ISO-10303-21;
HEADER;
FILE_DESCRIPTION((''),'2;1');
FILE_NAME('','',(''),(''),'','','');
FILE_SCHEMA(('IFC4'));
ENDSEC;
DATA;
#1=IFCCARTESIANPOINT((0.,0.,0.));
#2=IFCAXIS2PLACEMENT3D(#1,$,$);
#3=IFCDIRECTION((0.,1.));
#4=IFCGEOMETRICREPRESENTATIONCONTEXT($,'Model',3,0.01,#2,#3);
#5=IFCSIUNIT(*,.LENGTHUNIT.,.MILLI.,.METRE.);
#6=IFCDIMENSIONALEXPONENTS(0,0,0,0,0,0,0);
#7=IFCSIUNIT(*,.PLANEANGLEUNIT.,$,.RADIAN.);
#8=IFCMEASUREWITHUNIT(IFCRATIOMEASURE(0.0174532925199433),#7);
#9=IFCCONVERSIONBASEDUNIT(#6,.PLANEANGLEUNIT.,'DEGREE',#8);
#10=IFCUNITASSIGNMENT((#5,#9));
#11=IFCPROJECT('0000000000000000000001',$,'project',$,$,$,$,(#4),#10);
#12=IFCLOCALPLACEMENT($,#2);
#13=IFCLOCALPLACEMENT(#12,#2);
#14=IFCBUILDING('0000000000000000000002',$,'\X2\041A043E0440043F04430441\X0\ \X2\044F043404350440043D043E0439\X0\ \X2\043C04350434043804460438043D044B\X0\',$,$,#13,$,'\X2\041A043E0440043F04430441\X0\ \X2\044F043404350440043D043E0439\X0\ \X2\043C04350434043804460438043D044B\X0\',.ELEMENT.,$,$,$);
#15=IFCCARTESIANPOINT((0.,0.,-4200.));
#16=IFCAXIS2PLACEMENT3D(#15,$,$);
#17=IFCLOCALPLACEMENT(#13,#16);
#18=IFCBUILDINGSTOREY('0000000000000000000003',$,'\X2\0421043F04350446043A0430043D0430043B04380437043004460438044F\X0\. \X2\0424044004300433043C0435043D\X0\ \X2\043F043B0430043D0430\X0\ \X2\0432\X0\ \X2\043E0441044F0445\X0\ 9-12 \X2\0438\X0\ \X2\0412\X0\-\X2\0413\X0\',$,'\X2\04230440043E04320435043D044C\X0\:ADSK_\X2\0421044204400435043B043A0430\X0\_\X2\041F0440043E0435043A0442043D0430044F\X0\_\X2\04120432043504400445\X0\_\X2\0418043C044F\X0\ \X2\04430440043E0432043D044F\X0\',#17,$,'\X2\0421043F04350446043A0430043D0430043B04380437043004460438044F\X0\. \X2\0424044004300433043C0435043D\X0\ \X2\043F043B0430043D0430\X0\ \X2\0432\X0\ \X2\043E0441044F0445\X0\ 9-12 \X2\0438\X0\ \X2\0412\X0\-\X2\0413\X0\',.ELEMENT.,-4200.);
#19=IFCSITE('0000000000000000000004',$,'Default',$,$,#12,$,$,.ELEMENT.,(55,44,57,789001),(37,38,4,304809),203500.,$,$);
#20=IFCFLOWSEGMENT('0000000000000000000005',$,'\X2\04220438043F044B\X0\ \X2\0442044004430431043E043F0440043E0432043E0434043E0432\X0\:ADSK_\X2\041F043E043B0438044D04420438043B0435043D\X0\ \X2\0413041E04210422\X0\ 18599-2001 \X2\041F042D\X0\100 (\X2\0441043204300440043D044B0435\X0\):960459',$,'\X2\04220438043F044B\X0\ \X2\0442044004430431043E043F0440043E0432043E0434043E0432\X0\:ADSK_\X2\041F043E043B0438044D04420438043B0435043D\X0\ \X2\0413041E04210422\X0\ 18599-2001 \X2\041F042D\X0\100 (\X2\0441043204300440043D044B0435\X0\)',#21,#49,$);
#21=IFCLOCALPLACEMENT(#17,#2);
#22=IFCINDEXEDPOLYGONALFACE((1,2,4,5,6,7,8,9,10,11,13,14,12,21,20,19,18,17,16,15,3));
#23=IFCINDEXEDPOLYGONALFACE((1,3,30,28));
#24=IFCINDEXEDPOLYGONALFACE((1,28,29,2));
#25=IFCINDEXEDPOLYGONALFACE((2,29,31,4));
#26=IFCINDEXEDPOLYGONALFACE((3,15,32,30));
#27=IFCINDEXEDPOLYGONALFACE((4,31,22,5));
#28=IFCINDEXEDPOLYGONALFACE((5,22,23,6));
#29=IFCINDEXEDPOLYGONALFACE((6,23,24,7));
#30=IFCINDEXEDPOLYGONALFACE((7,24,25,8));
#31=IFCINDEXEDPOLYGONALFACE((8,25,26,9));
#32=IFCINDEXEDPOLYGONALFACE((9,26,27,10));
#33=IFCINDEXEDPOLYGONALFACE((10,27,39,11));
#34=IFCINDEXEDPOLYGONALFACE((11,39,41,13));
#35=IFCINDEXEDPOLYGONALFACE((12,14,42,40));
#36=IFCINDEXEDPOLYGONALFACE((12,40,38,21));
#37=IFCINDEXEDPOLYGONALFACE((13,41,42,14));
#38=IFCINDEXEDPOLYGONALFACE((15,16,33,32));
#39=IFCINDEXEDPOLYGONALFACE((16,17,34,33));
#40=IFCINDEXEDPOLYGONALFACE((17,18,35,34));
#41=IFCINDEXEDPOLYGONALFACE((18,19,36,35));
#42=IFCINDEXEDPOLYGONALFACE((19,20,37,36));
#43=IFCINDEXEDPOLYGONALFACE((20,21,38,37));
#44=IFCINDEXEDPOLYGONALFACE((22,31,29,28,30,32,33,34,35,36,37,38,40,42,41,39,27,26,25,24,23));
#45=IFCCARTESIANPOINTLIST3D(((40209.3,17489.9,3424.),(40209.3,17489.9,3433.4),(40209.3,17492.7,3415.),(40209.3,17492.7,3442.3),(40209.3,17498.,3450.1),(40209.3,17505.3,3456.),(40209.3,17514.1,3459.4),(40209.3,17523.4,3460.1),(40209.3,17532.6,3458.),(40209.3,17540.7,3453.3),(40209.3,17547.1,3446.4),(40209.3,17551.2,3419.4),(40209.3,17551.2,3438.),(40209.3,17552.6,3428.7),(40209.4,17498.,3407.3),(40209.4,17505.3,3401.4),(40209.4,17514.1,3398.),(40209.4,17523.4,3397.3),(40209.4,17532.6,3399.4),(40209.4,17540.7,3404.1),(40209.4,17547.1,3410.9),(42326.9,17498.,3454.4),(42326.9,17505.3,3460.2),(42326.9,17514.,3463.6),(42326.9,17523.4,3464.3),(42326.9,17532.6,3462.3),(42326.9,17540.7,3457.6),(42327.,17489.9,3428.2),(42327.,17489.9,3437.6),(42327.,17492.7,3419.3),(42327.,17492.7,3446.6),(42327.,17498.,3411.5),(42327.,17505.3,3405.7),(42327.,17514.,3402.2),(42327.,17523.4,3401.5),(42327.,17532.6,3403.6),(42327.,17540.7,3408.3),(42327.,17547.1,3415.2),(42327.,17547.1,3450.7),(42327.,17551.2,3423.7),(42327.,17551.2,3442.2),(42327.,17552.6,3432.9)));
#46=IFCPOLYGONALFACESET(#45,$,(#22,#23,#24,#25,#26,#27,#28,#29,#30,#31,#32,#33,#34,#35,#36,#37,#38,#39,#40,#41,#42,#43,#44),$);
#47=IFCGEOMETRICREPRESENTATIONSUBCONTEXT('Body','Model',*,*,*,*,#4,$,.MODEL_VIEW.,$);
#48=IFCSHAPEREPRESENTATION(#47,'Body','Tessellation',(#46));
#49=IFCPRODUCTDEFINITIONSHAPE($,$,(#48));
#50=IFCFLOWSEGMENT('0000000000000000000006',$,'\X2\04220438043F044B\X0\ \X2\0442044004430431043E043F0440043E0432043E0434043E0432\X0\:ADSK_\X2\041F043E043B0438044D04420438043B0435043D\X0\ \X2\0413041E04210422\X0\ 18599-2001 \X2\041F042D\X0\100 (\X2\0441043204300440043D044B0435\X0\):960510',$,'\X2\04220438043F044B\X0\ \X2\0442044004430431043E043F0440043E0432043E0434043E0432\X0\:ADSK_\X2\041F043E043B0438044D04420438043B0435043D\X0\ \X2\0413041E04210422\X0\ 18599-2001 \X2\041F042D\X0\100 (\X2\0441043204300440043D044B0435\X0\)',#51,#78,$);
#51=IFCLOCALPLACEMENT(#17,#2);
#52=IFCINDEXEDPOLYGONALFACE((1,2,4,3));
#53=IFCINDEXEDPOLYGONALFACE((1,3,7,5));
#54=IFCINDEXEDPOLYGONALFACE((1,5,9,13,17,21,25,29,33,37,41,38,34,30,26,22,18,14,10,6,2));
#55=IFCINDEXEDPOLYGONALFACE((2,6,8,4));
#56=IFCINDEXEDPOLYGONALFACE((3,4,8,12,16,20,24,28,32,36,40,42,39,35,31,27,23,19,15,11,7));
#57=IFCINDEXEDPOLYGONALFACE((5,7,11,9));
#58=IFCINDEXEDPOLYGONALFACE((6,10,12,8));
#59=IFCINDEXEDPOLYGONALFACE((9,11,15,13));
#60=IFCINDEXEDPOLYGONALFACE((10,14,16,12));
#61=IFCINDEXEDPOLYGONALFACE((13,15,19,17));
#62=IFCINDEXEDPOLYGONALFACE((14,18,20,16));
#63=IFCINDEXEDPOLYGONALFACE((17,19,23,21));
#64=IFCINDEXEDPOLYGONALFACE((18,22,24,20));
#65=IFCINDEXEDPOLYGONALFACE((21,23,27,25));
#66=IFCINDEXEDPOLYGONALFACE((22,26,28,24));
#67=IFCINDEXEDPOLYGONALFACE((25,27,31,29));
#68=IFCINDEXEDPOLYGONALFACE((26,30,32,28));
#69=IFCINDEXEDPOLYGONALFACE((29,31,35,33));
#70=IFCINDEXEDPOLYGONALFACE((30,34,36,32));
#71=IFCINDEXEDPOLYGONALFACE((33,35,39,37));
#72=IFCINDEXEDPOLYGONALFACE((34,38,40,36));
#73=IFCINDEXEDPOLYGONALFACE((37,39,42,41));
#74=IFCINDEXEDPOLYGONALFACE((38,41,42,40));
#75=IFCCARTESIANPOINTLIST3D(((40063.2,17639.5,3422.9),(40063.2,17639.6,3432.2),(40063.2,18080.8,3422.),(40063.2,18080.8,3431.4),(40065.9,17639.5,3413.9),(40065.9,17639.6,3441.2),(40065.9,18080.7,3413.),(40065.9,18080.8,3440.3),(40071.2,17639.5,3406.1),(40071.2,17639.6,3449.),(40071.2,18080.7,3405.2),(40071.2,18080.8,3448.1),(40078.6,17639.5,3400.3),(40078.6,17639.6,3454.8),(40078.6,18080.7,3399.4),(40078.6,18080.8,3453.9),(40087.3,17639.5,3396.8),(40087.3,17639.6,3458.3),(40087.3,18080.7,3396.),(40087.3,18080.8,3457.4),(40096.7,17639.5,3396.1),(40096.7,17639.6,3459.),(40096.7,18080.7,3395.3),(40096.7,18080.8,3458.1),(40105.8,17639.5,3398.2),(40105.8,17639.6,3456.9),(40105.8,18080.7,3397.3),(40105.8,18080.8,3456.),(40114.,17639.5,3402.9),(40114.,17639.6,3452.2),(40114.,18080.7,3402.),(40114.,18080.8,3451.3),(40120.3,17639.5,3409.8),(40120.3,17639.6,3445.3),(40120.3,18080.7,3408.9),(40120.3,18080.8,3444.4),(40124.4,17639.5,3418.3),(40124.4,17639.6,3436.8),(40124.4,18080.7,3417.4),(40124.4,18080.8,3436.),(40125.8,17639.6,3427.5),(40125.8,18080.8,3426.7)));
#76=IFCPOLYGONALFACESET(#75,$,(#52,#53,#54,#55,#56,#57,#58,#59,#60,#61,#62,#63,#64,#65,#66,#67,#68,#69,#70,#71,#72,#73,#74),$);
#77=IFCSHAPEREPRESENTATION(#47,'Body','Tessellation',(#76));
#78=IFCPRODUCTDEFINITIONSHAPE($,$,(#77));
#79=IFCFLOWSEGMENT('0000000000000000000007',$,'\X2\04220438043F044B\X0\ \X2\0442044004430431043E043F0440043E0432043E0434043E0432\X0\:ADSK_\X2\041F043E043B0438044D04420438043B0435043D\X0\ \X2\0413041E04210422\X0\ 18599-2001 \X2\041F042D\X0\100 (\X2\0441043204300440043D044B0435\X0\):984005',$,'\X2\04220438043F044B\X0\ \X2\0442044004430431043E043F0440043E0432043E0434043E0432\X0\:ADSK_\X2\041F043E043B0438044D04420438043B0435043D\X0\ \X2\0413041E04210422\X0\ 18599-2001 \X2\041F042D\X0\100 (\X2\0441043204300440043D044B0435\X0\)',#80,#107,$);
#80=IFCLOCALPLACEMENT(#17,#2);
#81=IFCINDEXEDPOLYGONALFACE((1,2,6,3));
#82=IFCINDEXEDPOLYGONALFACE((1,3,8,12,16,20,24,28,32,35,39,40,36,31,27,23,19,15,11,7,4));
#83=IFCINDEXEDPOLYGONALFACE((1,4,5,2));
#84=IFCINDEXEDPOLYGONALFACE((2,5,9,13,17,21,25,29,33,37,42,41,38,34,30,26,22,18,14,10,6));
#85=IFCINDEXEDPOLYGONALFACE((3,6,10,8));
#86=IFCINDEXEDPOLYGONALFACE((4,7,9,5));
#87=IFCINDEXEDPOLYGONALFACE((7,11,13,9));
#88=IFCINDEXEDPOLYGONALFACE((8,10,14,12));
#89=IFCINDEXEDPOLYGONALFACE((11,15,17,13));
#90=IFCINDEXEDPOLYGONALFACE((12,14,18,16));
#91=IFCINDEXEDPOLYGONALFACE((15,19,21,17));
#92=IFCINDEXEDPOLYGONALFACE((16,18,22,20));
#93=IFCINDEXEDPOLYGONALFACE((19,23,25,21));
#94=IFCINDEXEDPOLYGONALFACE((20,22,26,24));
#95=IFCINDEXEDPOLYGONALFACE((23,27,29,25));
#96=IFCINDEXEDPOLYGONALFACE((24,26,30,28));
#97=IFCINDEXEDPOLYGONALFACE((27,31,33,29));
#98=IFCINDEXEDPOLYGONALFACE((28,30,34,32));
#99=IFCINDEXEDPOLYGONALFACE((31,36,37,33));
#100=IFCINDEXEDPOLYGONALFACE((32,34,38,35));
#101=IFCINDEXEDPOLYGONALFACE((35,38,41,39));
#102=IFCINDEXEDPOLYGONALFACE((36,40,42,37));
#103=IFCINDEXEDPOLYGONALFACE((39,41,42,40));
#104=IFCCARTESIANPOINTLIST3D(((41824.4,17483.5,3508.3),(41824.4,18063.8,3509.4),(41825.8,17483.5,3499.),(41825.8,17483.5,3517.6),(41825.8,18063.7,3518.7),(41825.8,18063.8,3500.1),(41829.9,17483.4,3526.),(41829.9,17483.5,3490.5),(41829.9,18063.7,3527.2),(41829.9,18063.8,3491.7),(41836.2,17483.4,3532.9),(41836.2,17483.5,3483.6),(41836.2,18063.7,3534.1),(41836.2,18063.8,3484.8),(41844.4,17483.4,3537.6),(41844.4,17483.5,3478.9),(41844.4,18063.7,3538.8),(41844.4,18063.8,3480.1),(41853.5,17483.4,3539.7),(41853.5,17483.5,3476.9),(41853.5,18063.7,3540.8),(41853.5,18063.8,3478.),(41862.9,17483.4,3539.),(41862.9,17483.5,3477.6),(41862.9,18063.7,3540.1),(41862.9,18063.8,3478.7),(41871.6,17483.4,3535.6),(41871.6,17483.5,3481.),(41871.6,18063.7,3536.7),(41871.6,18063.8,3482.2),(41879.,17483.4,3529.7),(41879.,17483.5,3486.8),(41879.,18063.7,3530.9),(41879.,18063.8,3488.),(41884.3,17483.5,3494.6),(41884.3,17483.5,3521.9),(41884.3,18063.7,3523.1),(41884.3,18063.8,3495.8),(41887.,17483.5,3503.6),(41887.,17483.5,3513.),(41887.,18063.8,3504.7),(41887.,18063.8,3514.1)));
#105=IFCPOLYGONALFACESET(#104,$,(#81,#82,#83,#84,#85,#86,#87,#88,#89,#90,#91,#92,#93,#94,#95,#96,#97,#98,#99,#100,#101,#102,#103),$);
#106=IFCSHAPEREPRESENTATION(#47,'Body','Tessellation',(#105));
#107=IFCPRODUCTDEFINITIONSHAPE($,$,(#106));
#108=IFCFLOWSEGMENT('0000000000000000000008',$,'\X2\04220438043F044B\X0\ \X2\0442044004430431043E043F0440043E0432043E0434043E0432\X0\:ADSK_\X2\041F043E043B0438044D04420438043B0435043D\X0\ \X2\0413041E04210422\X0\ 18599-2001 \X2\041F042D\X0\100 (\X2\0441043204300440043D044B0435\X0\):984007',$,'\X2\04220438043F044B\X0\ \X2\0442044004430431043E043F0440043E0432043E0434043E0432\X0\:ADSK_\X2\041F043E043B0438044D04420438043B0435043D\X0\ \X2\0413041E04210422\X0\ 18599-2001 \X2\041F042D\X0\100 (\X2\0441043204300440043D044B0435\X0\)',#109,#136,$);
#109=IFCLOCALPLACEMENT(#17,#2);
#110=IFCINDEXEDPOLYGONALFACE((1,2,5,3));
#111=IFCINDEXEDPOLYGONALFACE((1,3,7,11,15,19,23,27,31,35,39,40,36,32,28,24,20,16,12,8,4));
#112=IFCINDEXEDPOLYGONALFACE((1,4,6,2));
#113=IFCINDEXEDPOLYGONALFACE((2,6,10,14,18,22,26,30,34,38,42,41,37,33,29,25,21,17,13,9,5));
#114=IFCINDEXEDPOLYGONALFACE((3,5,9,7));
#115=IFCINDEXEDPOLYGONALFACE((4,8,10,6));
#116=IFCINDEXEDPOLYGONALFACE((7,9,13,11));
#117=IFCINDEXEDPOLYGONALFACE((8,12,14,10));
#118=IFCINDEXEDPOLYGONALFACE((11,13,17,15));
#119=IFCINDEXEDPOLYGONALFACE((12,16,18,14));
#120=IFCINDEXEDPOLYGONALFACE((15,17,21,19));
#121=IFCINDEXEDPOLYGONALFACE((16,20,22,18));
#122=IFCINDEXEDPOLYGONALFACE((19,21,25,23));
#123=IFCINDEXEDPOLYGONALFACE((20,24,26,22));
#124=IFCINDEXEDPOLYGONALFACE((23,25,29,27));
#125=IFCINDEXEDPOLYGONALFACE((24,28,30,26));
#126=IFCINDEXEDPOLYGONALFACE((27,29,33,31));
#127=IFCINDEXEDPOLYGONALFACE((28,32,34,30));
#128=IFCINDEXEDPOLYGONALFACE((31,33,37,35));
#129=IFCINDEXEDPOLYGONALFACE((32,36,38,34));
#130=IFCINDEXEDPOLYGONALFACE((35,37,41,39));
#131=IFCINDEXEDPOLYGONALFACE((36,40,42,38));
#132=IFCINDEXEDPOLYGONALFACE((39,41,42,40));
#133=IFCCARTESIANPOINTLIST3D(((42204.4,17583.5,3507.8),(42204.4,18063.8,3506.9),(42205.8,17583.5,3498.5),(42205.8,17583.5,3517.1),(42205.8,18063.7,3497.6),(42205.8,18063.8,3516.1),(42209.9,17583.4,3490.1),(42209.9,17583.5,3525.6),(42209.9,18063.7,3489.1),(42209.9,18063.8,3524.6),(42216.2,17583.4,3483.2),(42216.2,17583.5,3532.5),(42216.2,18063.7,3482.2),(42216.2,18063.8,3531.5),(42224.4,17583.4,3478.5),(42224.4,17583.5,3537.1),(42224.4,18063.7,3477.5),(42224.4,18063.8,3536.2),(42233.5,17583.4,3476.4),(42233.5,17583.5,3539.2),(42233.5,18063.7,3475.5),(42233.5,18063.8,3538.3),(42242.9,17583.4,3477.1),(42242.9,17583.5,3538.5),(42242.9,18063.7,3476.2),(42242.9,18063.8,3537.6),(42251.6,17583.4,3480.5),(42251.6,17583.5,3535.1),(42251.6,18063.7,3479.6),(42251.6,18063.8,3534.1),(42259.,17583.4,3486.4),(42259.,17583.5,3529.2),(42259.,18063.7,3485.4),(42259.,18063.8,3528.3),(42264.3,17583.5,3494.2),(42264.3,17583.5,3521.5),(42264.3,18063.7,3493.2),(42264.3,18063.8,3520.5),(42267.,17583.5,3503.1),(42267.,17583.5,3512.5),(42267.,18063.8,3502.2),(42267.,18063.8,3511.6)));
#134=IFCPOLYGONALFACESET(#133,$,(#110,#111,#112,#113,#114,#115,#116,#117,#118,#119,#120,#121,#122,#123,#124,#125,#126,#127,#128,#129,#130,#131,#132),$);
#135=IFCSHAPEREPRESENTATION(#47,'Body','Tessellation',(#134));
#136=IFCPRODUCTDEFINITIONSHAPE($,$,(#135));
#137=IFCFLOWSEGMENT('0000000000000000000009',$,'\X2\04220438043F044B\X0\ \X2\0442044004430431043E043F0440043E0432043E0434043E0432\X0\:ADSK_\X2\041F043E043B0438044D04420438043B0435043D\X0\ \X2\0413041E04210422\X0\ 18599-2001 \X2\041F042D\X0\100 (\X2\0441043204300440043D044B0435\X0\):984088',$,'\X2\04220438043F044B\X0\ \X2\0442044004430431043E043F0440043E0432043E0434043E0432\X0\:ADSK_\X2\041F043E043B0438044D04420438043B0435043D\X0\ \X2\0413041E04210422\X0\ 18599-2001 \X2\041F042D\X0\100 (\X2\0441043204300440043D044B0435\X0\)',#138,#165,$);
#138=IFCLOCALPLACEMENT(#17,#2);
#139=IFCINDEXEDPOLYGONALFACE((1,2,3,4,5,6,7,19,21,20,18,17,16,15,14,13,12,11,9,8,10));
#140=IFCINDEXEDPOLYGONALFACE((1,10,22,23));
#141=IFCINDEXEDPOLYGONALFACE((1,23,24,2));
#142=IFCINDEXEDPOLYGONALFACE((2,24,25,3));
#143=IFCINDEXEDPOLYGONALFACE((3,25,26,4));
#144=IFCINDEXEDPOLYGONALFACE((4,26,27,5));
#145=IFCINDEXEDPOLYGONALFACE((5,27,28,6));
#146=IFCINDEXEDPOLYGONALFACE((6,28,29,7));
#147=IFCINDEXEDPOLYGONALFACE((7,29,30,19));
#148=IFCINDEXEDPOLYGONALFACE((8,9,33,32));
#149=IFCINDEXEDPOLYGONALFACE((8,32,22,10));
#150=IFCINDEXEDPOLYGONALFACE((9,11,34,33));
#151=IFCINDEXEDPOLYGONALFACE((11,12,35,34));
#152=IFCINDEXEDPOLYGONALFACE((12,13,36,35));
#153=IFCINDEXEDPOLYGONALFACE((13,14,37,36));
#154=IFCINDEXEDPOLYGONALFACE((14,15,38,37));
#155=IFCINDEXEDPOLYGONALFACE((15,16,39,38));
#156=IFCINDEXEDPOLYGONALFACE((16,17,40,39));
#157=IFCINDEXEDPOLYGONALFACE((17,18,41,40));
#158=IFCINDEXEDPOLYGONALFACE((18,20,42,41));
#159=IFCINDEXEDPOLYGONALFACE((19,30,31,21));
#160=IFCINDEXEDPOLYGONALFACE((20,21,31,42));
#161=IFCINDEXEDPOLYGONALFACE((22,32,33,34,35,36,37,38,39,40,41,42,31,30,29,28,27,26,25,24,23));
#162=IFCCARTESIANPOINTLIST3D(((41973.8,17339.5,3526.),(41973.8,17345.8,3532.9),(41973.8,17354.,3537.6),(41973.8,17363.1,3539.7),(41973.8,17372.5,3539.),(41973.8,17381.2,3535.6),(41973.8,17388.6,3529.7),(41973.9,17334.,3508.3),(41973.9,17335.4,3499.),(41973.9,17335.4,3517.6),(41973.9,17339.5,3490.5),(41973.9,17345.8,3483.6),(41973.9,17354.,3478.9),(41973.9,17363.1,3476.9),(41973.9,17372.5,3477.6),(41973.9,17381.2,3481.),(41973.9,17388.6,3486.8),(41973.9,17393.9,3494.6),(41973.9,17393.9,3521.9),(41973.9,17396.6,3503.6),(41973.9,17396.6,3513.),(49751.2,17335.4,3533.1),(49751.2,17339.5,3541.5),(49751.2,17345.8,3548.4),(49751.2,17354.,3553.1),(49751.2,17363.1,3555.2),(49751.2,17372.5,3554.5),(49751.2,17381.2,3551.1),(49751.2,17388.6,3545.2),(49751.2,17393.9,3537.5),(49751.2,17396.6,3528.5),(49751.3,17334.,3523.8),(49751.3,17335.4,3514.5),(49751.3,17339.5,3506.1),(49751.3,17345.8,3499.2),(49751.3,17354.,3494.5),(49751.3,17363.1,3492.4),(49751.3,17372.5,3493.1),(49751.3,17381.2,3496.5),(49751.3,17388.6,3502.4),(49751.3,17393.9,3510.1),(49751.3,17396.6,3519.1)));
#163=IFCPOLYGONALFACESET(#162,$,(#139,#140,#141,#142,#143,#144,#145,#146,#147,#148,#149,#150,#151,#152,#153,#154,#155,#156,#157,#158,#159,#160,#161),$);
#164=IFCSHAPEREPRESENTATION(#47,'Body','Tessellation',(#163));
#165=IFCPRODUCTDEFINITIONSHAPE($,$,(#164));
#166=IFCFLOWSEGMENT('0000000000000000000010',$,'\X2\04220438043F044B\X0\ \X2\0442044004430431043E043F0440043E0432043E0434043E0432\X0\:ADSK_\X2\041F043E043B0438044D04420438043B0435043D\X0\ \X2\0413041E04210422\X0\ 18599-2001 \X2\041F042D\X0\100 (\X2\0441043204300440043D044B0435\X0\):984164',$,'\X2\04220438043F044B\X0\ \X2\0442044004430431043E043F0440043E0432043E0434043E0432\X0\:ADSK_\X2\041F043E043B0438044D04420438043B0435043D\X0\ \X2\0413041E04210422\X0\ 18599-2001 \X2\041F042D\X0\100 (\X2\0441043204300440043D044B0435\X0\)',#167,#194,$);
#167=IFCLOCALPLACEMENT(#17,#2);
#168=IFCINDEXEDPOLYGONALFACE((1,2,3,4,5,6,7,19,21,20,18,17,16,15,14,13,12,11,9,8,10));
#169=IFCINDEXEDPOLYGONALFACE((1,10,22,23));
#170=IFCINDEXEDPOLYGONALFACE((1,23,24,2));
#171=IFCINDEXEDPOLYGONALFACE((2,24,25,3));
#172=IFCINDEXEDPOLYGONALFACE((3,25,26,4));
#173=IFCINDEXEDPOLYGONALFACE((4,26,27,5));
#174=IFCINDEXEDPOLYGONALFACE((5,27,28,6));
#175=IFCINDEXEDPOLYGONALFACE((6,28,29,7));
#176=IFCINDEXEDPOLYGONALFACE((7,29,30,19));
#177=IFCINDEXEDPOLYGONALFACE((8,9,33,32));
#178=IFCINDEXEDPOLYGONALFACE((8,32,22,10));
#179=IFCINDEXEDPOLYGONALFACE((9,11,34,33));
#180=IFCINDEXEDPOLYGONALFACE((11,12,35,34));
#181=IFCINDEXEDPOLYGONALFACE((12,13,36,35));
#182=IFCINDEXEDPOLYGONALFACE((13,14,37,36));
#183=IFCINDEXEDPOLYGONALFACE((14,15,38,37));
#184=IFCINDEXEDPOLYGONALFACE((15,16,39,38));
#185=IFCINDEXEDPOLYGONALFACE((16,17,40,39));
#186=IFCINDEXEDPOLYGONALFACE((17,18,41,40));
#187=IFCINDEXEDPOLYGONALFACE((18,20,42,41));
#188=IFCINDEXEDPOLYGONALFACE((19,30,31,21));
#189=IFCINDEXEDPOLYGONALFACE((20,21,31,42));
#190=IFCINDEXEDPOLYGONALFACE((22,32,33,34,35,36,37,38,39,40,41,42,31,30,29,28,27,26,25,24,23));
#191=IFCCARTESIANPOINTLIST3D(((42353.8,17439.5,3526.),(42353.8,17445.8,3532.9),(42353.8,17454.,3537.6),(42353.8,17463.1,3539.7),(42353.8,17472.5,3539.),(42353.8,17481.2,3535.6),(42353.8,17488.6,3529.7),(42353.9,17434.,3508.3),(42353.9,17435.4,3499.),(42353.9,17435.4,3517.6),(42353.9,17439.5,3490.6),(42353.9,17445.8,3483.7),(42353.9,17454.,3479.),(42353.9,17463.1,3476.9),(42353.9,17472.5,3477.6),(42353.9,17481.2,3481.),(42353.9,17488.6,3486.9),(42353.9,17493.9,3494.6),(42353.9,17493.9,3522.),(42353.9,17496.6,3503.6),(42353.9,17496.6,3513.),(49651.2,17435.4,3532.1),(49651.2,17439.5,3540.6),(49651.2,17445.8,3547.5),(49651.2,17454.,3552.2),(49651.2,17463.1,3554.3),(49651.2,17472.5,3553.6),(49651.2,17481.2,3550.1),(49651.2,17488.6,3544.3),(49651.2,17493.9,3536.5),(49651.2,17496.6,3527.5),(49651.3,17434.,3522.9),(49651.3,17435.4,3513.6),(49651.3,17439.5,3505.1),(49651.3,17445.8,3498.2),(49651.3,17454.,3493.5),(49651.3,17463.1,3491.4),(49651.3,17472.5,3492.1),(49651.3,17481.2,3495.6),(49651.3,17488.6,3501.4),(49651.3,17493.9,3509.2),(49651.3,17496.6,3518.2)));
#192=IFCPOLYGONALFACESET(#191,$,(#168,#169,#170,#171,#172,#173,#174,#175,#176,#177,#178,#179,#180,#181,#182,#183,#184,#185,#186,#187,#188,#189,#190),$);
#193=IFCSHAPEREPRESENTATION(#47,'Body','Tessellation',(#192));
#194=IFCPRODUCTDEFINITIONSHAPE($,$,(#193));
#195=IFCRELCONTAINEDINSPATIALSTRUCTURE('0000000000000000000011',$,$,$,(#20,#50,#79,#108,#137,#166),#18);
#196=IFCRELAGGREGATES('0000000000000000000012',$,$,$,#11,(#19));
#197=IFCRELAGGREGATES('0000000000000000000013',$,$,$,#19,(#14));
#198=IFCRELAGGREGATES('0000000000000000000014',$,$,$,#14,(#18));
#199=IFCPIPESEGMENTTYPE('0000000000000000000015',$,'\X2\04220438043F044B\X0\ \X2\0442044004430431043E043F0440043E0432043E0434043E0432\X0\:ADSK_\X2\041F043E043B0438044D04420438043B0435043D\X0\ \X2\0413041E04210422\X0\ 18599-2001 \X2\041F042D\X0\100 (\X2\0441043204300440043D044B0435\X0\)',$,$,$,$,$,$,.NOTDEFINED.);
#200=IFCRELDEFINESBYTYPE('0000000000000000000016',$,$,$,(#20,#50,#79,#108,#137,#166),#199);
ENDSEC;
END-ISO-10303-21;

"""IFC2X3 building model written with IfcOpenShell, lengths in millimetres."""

from ifc_helpers import new_model, entity, si_unit, converted_unit, direction, frame, frame_2d, origin, origin_2d_with_axis, place, context, subcontext, project, spatial, circle, extrude, type_object, element, save


model = new_model("IFC2X3")

# Units and contexts
model_context = context("Model", 3, precision=0.01, world=origin(), true_north=direction((0.0, 1.0)))
body_context = subcontext(model_context, "Body", "Model", "MODEL_VIEW")
ifc_project = project(units=[si_unit("LENGTHUNIT", "METRE", prefix="MILLI"), converted_unit("PLANEANGLEUNIT", "DEGREE", entity("IfcRatioMeasure", 0.0174532925199433), si_unit("PLANEANGLEUNIT", "RADIAN"), dimensions=[0, 0, 0, 0, 0, 0, 0])], contexts=[model_context])

# Site, building, storey
site_placement = place(None, frame((0.0, 0.0, 0.0)))
site = spatial("IfcSite", under=ifc_project, at=site_placement, Name="Default", CompositionType="ELEMENT", RefLatitude=(55, 44, 57, 789001), RefLongitude=(37, 38, 4, 304809), RefElevation=203500.0)
building_placement = place(site_placement, origin())
building = spatial("IfcBuilding", under=site, at=building_placement, Name="Корпус ядерной медицины", LongName="Корпус ядерной медицины", CompositionType="ELEMENT")
storey_placement = place(building_placement, frame((0.0, 0.0, -4200.0)))
storey = spatial("IfcBuildingStorey", under=building, at=storey_placement, Name="Спецканализация. Фрагмен плана в осях 9-12 и В-Г", ObjectType="Уровень:ADSK_Стрелка_Проектная_Вверх_Имя уровня", LongName="Спецканализация. Фрагмен плана в осях 9-12 и В-Г", CompositionType="ELEMENT", Elevation=-4200.0)

# Flow segments
pipe_segment_type = type_object("IfcPipeSegmentType", Name="Типы трубопроводов:ADSK_Полиэтилен ГОСТ 18599-2001 ПЭ100 (сварные)", PredefinedType="NOTDEFINED")
flow_segment_1_placement = place(storey_placement, frame((40209.3, 17488.0, 3395.6)))
element("IfcFlowSegment", 1, at=flow_segment_1_placement, inside=storey, type_object=pipe_segment_type, Name="Типы трубопроводов:ADSK_Полиэтилен ГОСТ 18599-2001 ПЭ100 (сварные):960459", ObjectType="Типы трубопроводов:ADSK_Полиэтилен ГОСТ 18599-2001 ПЭ100 (сварные)", context=body_context, shape_type="SweptSolid", body=[
    extrude(circle(Radius=31.5, at=frame_2d((0.0, 0.0), x_axis=(1.0, 0.0))), frame((0.1, 33.1, 33.1), z_axis=(0.999998, -0.000004, 0.002009), x_axis=(0.000004, 1.0, 0.0)), (0.0, 0.0, 1.0), 2117.7),
])
flow_segment_2_placement = place(storey_placement, frame((40061.2, 17639.5, 3393.6)))
element("IfcFlowSegment", 2, at=flow_segment_2_placement, inside=storey, type_object=pipe_segment_type, Name="Типы трубопроводов:ADSK_Полиэтилен ГОСТ 18599-2001 ПЭ100 (сварные):960510", ObjectType="Типы трубопроводов:ADSK_Полиэтилен ГОСТ 18599-2001 ПЭ100 (сварные)", context=body_context, shape_type="SweptSolid", body=[
    extrude(circle(Radius=31.5, at=origin_2d_with_axis()), frame((33.1, 441.3, 33.1), z_axis=(0.0, -0.999998, 0.002), x_axis=(1.0, 0.0, 0.0)), (0.0, 0.0, 1.0), 441.2),
])
flow_segment_3_placement = place(storey_placement, frame((41822.8, 17483.4, 3475.2)))
element("IfcFlowSegment", 3, at=flow_segment_3_placement, inside=storey, type_object=pipe_segment_type, Name="Типы трубопроводов:ADSK_Полиэтилен ГОСТ 18599-2001 ПЭ100 (сварные):984005", ObjectType="Типы трубопроводов:ADSK_Полиэтилен ГОСТ 18599-2001 ПЭ100 (сварные)", context=body_context, shape_type="SweptSolid", body=[
    extrude(circle(Radius=31.5, at=origin_2d_with_axis()), frame((33.1, 0.1, 33.1), z_axis=(0.0, 0.999998, 0.002), x_axis=(-1.0, 0.0, 0.0)), (0.0, 0.0, 1.0), 580.3),
])
flow_segment_4_placement = place(storey_placement, frame((42202.8, 17583.4, 3473.8)))
element("IfcFlowSegment", 4, at=flow_segment_4_placement, inside=storey, type_object=pipe_segment_type, Name="Типы трубопроводов:ADSK_Полиэтилен ГОСТ 18599-2001 ПЭ100 (сварные):984007", ObjectType="Типы трубопроводов:ADSK_Полиэтилен ГОСТ 18599-2001 ПЭ100 (сварные)", context=body_context, shape_type="SweptSolid", body=[
    extrude(circle(Radius=31.5, at=frame_2d((0.0, 0.0), x_axis=(1.0, 0.0))), frame((33.1, 480.4, 33.1), z_axis=(0.0, -0.999998, 0.002), x_axis=(-1.0, 0.0, 0.0)), (0.0, 0.0, 1.0), 480.3),
])
flow_segment_5_placement = place(storey_placement, frame((41973.8, 17332.4, 3475.2)))
element("IfcFlowSegment", 5, at=flow_segment_5_placement, inside=storey, type_object=pipe_segment_type, Name="Типы трубопроводов:ADSK_Полиэтилен ГОСТ 18599-2001 ПЭ100 (сварные):984088", ObjectType="Типы трубопроводов:ADSK_Полиэтилен ГОСТ 18599-2001 ПЭ100 (сварные)", context=body_context, shape_type="SweptSolid", body=[
    extrude(circle(Radius=31.5, at=frame_2d((0.0, 0.0), x_axis=(1.0, 0.0))), frame((0.1, 33.1, 33.1), z_axis=(0.999998, 0.0, 0.001997), x_axis=(0.0, -1.0, 0.0)), (0.0, 0.0, 1.0), 7777.4),
])
flow_segment_6_placement = place(storey_placement, frame((42353.8, 17432.4, 3475.2)))
element("IfcFlowSegment", 6, at=flow_segment_6_placement, inside=storey, type_object=pipe_segment_type, Name="Типы трубопроводов:ADSK_Полиэтилен ГОСТ 18599-2001 ПЭ100 (сварные):984164", ObjectType="Типы трубопроводов:ADSK_Полиэтилен ГОСТ 18599-2001 ПЭ100 (сварные)", context=body_context, shape_type="SweptSolid", body=[
    extrude(circle(Radius=31.5, at=origin_2d_with_axis()), frame((0.1, 33.1, 33.1), z_axis=(0.999998, 0.0, 0.001995), x_axis=(0.0, -1.0, 0.0)), (0.0, 0.0, 1.0), 7297.4),
])

save(model, "model.ifc")
